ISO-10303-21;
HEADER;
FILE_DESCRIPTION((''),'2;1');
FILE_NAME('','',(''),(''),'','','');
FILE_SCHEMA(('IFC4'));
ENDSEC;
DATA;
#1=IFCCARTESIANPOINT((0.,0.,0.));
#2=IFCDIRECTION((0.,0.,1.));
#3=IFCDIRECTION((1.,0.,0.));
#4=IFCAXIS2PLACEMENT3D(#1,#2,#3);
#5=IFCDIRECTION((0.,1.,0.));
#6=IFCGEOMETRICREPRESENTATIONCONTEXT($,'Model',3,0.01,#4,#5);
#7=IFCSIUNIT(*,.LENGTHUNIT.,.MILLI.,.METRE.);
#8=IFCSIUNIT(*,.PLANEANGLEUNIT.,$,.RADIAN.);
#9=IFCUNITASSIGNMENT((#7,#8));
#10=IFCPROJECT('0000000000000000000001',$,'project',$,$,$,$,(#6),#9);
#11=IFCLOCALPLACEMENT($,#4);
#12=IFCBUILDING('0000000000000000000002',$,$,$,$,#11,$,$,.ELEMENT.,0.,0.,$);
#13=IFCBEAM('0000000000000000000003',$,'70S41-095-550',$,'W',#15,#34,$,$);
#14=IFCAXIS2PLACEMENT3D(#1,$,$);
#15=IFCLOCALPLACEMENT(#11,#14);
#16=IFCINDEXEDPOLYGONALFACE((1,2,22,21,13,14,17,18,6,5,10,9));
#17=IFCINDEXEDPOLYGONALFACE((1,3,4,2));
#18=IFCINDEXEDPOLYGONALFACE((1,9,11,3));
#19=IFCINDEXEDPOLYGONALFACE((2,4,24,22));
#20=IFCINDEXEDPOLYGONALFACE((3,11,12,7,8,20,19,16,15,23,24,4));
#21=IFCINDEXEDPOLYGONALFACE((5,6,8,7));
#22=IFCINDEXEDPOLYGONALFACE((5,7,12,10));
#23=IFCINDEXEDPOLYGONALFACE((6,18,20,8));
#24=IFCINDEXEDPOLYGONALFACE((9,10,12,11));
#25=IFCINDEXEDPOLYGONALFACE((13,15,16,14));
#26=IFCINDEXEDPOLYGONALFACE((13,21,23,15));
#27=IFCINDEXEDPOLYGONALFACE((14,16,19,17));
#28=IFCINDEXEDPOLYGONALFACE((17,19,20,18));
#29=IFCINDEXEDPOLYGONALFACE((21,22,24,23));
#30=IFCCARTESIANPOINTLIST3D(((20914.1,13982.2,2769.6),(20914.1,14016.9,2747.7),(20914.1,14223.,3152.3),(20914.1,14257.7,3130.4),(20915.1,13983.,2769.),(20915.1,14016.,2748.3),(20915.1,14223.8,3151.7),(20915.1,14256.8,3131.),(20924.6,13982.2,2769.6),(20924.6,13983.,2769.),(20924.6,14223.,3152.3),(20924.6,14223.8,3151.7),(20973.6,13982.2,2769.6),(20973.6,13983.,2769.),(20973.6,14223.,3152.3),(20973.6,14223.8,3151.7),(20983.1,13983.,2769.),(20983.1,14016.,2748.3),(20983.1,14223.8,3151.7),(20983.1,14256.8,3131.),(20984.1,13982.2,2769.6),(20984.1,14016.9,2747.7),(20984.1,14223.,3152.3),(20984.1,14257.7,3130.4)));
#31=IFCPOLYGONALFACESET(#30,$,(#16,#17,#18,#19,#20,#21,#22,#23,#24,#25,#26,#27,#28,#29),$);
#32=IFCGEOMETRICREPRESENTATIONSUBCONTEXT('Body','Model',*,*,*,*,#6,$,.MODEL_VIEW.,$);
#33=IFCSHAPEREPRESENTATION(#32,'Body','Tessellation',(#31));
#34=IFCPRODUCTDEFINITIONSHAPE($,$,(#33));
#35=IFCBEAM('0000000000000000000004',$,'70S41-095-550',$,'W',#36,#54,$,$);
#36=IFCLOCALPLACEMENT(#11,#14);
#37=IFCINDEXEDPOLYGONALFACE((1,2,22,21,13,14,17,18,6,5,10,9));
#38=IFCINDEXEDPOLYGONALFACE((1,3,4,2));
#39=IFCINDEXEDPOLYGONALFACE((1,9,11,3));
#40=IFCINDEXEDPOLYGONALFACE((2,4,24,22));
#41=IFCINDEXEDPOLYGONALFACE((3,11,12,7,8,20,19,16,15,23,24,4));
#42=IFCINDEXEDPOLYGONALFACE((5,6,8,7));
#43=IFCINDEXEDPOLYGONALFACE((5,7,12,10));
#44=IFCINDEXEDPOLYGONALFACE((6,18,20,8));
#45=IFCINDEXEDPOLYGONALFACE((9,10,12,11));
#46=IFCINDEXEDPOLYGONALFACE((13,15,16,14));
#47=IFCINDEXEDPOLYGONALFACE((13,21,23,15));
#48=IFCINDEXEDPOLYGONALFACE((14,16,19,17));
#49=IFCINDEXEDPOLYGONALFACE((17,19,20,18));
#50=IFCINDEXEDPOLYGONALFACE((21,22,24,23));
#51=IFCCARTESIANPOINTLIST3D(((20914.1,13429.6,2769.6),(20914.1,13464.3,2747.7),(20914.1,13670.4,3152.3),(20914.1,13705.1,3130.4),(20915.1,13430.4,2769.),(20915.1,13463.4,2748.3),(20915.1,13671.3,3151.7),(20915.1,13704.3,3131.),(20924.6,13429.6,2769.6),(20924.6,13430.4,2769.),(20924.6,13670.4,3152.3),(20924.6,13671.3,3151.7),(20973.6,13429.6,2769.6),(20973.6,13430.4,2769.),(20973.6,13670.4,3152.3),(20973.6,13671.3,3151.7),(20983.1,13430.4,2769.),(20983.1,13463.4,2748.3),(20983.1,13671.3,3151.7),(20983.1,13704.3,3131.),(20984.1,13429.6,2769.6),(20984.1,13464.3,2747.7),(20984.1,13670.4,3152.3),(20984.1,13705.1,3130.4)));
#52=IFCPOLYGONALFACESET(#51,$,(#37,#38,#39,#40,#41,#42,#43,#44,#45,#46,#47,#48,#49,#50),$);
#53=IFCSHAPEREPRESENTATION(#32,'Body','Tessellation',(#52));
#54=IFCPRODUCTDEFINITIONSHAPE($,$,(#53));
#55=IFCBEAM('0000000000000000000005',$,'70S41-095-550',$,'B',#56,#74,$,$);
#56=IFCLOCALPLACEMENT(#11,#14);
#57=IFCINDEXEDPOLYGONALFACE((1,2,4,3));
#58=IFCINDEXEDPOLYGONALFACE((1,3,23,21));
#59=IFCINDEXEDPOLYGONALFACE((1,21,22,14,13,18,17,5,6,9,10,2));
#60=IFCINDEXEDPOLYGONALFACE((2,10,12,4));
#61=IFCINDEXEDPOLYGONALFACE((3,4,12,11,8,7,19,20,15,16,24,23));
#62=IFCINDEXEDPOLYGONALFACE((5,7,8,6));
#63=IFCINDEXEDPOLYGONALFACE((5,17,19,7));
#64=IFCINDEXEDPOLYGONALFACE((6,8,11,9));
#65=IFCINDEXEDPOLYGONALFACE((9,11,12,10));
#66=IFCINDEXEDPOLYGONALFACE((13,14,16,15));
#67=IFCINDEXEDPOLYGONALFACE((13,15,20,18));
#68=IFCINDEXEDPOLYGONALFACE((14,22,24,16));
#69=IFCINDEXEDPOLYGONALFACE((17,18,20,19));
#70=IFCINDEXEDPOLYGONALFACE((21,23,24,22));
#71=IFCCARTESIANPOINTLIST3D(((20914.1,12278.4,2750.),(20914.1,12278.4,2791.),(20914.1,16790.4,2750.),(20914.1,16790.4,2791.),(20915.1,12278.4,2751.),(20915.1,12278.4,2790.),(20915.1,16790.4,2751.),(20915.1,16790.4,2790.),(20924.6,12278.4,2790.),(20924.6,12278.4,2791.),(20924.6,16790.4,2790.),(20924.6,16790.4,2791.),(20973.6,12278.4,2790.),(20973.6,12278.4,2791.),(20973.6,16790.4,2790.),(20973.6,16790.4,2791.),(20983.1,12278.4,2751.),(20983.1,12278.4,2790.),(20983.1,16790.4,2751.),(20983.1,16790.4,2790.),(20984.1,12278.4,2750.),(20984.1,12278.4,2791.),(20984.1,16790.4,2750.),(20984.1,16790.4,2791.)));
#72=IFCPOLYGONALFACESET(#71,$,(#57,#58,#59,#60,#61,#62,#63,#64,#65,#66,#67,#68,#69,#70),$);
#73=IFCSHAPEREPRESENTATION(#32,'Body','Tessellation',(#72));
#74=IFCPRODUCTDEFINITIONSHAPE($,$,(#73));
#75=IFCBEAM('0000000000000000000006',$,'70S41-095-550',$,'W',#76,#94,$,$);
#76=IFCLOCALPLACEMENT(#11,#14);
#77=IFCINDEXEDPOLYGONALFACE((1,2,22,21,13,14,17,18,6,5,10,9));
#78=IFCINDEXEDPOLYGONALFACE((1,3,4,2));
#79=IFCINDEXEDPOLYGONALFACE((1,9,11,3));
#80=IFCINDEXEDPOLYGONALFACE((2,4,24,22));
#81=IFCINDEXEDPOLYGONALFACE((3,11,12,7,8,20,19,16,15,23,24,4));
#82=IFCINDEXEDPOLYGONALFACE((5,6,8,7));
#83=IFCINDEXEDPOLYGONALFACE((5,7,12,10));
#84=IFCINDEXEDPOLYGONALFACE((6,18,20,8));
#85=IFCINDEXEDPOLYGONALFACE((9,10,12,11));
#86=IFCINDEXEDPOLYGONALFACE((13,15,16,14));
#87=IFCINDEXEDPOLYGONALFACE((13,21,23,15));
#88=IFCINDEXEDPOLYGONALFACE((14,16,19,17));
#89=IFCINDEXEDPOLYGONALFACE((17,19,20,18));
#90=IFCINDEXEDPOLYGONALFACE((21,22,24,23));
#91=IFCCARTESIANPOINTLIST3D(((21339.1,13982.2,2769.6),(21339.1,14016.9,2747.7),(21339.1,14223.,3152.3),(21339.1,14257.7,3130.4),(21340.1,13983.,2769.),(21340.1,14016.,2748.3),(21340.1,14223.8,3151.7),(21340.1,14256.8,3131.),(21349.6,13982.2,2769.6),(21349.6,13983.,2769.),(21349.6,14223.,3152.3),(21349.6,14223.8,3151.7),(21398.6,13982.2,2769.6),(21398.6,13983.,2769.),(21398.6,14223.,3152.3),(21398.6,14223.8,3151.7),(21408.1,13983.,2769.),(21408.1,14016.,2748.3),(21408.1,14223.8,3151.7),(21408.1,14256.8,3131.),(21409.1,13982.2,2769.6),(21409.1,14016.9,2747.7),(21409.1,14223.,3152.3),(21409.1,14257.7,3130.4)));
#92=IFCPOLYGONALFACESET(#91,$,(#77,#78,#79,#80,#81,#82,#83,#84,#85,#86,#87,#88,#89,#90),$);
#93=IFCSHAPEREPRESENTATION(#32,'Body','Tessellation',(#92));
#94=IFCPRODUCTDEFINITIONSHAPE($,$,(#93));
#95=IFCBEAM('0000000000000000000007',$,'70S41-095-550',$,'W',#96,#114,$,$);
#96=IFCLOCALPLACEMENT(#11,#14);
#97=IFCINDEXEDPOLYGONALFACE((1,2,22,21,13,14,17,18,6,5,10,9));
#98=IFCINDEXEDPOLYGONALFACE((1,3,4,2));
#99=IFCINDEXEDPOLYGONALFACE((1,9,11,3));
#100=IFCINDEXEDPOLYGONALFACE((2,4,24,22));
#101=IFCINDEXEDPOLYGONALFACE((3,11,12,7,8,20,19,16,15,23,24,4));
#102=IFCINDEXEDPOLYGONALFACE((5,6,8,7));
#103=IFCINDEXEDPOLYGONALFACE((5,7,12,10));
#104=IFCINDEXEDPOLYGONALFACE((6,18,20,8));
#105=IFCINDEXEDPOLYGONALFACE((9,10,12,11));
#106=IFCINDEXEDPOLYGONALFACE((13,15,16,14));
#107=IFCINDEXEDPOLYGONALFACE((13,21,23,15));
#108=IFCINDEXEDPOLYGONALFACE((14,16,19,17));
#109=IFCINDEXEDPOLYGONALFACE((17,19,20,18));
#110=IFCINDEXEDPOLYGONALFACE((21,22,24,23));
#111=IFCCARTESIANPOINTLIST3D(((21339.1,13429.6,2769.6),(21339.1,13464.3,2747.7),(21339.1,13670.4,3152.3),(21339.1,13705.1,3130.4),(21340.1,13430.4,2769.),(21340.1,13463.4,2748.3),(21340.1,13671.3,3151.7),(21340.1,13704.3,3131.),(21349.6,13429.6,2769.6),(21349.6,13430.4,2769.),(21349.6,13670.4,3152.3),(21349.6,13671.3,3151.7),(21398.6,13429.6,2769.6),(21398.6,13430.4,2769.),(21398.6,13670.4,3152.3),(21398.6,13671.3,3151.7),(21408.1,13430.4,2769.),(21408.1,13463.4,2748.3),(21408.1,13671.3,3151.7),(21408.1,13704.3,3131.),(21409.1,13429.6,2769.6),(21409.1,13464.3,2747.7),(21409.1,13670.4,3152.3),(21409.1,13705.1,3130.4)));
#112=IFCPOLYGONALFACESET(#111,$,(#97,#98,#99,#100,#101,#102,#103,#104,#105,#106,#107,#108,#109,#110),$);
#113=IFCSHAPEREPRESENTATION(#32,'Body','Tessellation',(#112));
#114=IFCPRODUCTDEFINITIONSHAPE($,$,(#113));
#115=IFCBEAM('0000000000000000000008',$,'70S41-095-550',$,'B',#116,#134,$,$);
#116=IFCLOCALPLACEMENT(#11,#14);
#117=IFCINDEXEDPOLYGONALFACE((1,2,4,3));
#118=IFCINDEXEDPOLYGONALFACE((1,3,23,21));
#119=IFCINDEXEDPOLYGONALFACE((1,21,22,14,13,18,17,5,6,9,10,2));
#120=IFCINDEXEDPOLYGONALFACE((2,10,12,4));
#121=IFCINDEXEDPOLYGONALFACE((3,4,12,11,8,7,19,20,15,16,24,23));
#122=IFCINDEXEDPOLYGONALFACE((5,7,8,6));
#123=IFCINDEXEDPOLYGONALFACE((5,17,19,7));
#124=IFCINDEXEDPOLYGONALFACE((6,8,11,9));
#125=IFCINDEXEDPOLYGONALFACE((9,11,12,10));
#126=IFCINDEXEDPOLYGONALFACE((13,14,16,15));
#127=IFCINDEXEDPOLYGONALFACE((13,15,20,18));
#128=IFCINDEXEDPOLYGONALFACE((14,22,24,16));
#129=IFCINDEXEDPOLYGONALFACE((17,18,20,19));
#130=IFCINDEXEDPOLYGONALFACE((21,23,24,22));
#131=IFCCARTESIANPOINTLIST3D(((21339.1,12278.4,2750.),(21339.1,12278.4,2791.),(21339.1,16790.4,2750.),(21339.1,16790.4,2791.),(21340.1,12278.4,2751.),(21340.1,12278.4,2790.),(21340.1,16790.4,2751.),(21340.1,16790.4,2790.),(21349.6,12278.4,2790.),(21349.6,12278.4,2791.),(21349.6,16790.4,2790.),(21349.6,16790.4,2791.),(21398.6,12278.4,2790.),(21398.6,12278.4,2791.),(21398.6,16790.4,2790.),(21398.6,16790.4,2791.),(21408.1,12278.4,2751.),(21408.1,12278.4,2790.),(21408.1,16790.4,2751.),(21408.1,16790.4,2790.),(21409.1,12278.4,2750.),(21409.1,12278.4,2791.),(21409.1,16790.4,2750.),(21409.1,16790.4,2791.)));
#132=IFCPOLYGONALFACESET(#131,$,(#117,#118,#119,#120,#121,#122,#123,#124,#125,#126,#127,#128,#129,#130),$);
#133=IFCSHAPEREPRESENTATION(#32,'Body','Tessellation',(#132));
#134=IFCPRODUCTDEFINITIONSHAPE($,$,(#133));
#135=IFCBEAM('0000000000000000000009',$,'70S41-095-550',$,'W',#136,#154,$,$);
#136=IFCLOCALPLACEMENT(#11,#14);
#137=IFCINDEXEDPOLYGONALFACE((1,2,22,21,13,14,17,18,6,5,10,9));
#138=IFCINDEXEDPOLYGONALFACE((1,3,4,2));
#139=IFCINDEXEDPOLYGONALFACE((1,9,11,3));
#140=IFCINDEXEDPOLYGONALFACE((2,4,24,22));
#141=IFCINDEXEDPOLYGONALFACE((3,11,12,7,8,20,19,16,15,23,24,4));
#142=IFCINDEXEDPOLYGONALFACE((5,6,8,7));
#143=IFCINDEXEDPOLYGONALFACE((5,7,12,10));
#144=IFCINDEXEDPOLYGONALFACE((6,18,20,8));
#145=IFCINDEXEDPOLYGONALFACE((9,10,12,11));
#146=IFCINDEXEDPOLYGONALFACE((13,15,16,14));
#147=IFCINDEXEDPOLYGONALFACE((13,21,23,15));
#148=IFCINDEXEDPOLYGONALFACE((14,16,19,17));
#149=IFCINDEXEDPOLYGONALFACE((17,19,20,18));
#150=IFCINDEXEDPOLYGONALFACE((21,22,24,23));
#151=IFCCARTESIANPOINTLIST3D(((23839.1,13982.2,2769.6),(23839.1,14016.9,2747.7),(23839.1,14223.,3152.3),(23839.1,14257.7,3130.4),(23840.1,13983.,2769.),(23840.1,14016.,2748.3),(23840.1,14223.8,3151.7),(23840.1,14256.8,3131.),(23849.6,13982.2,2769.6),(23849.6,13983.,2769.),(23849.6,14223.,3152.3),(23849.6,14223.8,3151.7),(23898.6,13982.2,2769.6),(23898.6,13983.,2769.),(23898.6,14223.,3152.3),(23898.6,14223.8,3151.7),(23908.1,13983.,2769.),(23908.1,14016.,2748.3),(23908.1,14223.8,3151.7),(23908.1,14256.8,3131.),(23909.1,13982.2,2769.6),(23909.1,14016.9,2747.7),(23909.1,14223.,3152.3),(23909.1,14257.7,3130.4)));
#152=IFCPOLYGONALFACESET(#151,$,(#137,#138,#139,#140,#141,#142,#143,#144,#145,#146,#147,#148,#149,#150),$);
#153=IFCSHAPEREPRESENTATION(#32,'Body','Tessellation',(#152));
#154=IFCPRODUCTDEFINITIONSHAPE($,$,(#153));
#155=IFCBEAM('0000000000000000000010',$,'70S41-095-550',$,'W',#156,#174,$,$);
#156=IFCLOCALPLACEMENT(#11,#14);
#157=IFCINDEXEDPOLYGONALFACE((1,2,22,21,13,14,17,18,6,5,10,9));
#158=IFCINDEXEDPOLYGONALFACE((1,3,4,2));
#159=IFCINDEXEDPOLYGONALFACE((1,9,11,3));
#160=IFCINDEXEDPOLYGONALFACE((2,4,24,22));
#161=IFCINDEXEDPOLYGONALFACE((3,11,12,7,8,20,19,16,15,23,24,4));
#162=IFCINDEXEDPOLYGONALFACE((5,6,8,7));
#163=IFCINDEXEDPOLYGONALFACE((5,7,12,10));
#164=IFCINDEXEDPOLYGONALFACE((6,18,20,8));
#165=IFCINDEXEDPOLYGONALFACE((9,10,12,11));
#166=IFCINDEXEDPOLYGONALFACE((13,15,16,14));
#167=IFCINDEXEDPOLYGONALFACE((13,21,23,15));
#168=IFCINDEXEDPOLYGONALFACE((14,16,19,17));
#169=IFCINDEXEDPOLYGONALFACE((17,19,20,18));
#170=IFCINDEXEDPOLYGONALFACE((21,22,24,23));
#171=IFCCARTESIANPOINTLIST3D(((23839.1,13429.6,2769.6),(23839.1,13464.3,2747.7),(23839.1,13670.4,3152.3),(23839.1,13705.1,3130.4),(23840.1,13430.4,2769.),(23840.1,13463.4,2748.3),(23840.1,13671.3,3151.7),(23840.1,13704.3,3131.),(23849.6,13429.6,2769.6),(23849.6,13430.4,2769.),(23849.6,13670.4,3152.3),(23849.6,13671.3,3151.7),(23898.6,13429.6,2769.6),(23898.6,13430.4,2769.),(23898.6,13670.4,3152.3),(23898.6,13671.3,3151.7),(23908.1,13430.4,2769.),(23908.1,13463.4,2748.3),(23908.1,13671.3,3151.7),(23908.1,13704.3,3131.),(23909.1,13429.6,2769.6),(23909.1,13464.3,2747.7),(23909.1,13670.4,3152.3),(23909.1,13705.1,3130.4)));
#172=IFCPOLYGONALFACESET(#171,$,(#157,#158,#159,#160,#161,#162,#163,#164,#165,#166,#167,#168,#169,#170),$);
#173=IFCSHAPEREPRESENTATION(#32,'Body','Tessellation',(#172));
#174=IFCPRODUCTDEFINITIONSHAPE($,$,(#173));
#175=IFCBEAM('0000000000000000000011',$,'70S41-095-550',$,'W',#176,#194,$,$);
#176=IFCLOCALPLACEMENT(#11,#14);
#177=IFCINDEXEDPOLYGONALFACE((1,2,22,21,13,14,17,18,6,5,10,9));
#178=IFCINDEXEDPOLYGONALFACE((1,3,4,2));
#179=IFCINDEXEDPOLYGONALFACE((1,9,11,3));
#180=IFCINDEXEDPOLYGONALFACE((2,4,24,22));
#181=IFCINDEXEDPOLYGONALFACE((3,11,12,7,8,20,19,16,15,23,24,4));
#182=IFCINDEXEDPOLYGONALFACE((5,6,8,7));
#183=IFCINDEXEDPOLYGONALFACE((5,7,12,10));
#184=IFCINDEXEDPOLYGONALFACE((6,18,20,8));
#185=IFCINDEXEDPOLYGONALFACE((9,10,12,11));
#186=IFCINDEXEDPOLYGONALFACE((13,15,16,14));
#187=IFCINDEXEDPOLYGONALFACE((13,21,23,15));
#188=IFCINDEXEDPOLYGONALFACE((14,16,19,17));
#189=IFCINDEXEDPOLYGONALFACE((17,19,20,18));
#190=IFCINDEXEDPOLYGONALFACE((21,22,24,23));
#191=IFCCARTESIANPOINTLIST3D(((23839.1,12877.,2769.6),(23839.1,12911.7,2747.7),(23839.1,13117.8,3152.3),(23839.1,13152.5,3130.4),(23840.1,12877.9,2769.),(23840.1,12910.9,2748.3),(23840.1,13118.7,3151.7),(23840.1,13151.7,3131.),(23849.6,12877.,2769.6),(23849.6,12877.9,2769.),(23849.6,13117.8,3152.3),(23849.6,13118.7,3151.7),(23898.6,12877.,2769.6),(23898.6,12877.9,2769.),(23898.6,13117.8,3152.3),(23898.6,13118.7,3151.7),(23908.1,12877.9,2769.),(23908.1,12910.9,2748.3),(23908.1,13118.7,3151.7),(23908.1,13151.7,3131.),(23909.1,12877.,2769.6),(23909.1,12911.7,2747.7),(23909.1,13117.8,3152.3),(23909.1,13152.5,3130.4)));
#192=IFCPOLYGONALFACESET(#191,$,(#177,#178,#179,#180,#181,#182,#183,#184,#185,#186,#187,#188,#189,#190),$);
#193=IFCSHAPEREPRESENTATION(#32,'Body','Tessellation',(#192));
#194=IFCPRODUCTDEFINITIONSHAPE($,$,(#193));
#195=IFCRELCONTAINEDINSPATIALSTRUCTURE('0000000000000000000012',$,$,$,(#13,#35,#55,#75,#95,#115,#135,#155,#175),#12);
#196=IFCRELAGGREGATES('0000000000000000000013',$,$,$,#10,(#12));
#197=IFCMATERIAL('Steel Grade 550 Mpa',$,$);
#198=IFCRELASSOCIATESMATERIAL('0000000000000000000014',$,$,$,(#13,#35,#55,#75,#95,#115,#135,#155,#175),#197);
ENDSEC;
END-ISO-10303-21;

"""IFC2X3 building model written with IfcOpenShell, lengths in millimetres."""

from ifc_helpers import new_model, si_unit, direction, frame, origin, origin_with_axes, origin_2d_with_axis, place, context, subcontext, project, spatial, c_section, extrude, source, transform, mapped, material, element, save


model = new_model("IFC2X3")

# Units and contexts
model_context = context("Model", 3, precision=0.01, world=origin_with_axes(), true_north=direction((0.0, 1.0, 0.0)))
body_context = subcontext(model_context, "Body", "Model", "MODEL_VIEW")
ifc_project = project(units=[si_unit("LENGTHUNIT", "METRE", prefix="MILLI"), si_unit("PLANEANGLEUNIT", "RADIAN")], contexts=[model_context])

# Building
building_placement = place(None, origin_with_axes())
building = spatial("IfcBuilding", under=ifc_project, at=building_placement, CompositionType="ELEMENT", ElevationOfRefHeight=0.0, ElevationOfTerrain=0.0)

# Beams
ifc_material = material(Name="Steel Grade 550 Mpa")
shared_shape_1 = source(origin(), body_context, "Body", "SweptSolid", [
    extrude(c_section(Depth=70.0, Width=41.0, WallThickness=1.0, Girth=10.5, at=origin_2d_with_axis()), origin_with_axes(), (0.0, 0.0, 1.0), 452.2),
])
beam_1_placement = place(None, frame((20949.1, 13999.5, 2758.7), z_axis=(0.0, 0.532581, 0.846379), x_axis=(0.0, -0.846379, 0.532581)))
element("IfcBeam", 1, at=beam_1_placement, inside=building, material=ifc_material, Name="70S41-095-550", ObjectType="W", context=body_context, shape_type="MappedRepresentation", body=[
    mapped(shared_shape_1, transform((0.0, 0.0, 0.0), scale=1.0)),
])
shared_shape_2 = source(origin(), body_context, "Body", "SweptSolid", [
    extrude(c_section(Depth=70.0, Width=41.0, WallThickness=1.0, Girth=10.5, at=origin_2d_with_axis()), origin_with_axes(), (0.0, 0.0, 1.0), 452.2),
])
beam_2_placement = place(None, frame((20949.1, 13446.9, 2758.7), z_axis=(0.0, 0.532581, 0.846379), x_axis=(0.0, -0.846379, 0.532581)))
element("IfcBeam", 2, at=beam_2_placement, inside=building, material=ifc_material, Name="70S41-095-550", ObjectType="W", context=body_context, shape_type="MappedRepresentation", body=[
    mapped(shared_shape_2, transform((0.0, 0.0, 0.0), scale=1.0)),
])
shared_shape_3 = source(origin(), body_context, "Body", "SweptSolid", [
    extrude(c_section(Depth=70.0, Width=41.0, WallThickness=1.0, Girth=10.5, at=origin_2d_with_axis()), origin_with_axes(), (0.0, 0.0, 1.0), 4512.0),
])
beam_3_placement = place(None, frame((20949.1, 12278.4, 2770.5), z_axis=(0.0, 1.0, 0.0), x_axis=(0.0, 0.0, 1.0)))
element("IfcBeam", 3, at=beam_3_placement, inside=building, material=ifc_material, Name="70S41-095-550", ObjectType="B", context=body_context, shape_type="MappedRepresentation", body=[
    mapped(shared_shape_3, transform((0.0, 0.0, 0.0), scale=1.0)),
])
shared_shape_4 = source(origin(), body_context, "Body", "SweptSolid", [
    extrude(c_section(Depth=70.0, Width=41.0, WallThickness=1.0, Girth=10.5, at=origin_2d_with_axis()), origin_with_axes(), (0.0, 0.0, 1.0), 452.2),
])
beam_4_placement = place(None, frame((21374.1, 13999.5, 2758.7), z_axis=(0.0, 0.532581, 0.846379), x_axis=(0.0, -0.846379, 0.532581)))
element("IfcBeam", 4, at=beam_4_placement, inside=building, material=ifc_material, Name="70S41-095-550", ObjectType="W", context=body_context, shape_type="MappedRepresentation", body=[
    mapped(shared_shape_4, transform((0.0, 0.0, 0.0), scale=1.0)),
])
shared_shape_5 = source(origin(), body_context, "Body", "SweptSolid", [
    extrude(c_section(Depth=70.0, Width=41.0, WallThickness=1.0, Girth=10.5, at=origin_2d_with_axis()), origin_with_axes(), (0.0, 0.0, 1.0), 452.2),
])
beam_5_placement = place(None, frame((21374.1, 13446.9, 2758.7), z_axis=(0.0, 0.532581, 0.846379), x_axis=(0.0, -0.846379, 0.532581)))
element("IfcBeam", 5, at=beam_5_placement, inside=building, material=ifc_material, Name="70S41-095-550", ObjectType="W", context=body_context, shape_type="MappedRepresentation", body=[
    mapped(shared_shape_5, transform((0.0, 0.0, 0.0), scale=1.0)),
])
shared_shape_6 = source(origin(), body_context, "Body", "SweptSolid", [
    extrude(c_section(Depth=70.0, Width=41.0, WallThickness=1.0, Girth=10.5, at=origin_2d_with_axis()), origin_with_axes(), (0.0, 0.0, 1.0), 4512.0),
])
beam_6_placement = place(None, frame((21374.1, 12278.4, 2770.5), z_axis=(0.0, 1.0, 0.0), x_axis=(0.0, 0.0, 1.0)))
element("IfcBeam", 6, at=beam_6_placement, inside=building, material=ifc_material, Name="70S41-095-550", ObjectType="B", context=body_context, shape_type="MappedRepresentation", body=[
    mapped(shared_shape_6, transform((0.0, 0.0, 0.0), scale=1.0)),
])
shared_shape_7 = source(origin(), body_context, "Body", "SweptSolid", [
    extrude(c_section(Depth=70.0, Width=41.0, WallThickness=1.0, Girth=10.5, at=origin_2d_with_axis()), origin_with_axes(), (0.0, 0.0, 1.0), 452.2),
])
beam_7_placement = place(None, frame((23874.1, 13999.5, 2758.7), z_axis=(0.0, 0.532581, 0.846379), x_axis=(0.0, -0.846379, 0.532581)))
element("IfcBeam", 7, at=beam_7_placement, inside=building, material=ifc_material, Name="70S41-095-550", ObjectType="W", context=body_context, shape_type="MappedRepresentation", body=[
    mapped(shared_shape_7, transform((0.0, 0.0, 0.0), scale=1.0)),
])
shared_shape_8 = source(origin(), body_context, "Body", "SweptSolid", [
    extrude(c_section(Depth=70.0, Width=41.0, WallThickness=1.0, Girth=10.5, at=origin_2d_with_axis()), origin_with_axes(), (0.0, 0.0, 1.0), 452.2),
])
beam_8_placement = place(None, frame((23874.1, 13446.9, 2758.7), z_axis=(0.0, 0.532581, 0.846379), x_axis=(0.0, -0.846379, 0.532581)))
element("IfcBeam", 8, at=beam_8_placement, inside=building, material=ifc_material, Name="70S41-095-550", ObjectType="W", context=body_context, shape_type="MappedRepresentation", body=[
    mapped(shared_shape_8, transform((0.0, 0.0, 0.0), scale=1.0)),
])
shared_shape_9 = source(origin(), body_context, "Body", "SweptSolid", [
    extrude(c_section(Depth=70.0, Width=41.0, WallThickness=1.0, Girth=10.5, at=origin_2d_with_axis()), origin_with_axes(), (0.0, 0.0, 1.0), 452.2),
])
beam_9_placement = place(None, frame((23874.1, 12894.4, 2758.7), z_axis=(0.0, 0.532581, 0.846379), x_axis=(0.0, -0.846379, 0.532581)))
element("IfcBeam", 9, at=beam_9_placement, inside=building, material=ifc_material, Name="70S41-095-550", ObjectType="W", context=body_context, shape_type="MappedRepresentation", body=[
    mapped(shared_shape_9, transform((0.0, 0.0, 0.0), scale=1.0)),
])

save(model, "model.ifc")
